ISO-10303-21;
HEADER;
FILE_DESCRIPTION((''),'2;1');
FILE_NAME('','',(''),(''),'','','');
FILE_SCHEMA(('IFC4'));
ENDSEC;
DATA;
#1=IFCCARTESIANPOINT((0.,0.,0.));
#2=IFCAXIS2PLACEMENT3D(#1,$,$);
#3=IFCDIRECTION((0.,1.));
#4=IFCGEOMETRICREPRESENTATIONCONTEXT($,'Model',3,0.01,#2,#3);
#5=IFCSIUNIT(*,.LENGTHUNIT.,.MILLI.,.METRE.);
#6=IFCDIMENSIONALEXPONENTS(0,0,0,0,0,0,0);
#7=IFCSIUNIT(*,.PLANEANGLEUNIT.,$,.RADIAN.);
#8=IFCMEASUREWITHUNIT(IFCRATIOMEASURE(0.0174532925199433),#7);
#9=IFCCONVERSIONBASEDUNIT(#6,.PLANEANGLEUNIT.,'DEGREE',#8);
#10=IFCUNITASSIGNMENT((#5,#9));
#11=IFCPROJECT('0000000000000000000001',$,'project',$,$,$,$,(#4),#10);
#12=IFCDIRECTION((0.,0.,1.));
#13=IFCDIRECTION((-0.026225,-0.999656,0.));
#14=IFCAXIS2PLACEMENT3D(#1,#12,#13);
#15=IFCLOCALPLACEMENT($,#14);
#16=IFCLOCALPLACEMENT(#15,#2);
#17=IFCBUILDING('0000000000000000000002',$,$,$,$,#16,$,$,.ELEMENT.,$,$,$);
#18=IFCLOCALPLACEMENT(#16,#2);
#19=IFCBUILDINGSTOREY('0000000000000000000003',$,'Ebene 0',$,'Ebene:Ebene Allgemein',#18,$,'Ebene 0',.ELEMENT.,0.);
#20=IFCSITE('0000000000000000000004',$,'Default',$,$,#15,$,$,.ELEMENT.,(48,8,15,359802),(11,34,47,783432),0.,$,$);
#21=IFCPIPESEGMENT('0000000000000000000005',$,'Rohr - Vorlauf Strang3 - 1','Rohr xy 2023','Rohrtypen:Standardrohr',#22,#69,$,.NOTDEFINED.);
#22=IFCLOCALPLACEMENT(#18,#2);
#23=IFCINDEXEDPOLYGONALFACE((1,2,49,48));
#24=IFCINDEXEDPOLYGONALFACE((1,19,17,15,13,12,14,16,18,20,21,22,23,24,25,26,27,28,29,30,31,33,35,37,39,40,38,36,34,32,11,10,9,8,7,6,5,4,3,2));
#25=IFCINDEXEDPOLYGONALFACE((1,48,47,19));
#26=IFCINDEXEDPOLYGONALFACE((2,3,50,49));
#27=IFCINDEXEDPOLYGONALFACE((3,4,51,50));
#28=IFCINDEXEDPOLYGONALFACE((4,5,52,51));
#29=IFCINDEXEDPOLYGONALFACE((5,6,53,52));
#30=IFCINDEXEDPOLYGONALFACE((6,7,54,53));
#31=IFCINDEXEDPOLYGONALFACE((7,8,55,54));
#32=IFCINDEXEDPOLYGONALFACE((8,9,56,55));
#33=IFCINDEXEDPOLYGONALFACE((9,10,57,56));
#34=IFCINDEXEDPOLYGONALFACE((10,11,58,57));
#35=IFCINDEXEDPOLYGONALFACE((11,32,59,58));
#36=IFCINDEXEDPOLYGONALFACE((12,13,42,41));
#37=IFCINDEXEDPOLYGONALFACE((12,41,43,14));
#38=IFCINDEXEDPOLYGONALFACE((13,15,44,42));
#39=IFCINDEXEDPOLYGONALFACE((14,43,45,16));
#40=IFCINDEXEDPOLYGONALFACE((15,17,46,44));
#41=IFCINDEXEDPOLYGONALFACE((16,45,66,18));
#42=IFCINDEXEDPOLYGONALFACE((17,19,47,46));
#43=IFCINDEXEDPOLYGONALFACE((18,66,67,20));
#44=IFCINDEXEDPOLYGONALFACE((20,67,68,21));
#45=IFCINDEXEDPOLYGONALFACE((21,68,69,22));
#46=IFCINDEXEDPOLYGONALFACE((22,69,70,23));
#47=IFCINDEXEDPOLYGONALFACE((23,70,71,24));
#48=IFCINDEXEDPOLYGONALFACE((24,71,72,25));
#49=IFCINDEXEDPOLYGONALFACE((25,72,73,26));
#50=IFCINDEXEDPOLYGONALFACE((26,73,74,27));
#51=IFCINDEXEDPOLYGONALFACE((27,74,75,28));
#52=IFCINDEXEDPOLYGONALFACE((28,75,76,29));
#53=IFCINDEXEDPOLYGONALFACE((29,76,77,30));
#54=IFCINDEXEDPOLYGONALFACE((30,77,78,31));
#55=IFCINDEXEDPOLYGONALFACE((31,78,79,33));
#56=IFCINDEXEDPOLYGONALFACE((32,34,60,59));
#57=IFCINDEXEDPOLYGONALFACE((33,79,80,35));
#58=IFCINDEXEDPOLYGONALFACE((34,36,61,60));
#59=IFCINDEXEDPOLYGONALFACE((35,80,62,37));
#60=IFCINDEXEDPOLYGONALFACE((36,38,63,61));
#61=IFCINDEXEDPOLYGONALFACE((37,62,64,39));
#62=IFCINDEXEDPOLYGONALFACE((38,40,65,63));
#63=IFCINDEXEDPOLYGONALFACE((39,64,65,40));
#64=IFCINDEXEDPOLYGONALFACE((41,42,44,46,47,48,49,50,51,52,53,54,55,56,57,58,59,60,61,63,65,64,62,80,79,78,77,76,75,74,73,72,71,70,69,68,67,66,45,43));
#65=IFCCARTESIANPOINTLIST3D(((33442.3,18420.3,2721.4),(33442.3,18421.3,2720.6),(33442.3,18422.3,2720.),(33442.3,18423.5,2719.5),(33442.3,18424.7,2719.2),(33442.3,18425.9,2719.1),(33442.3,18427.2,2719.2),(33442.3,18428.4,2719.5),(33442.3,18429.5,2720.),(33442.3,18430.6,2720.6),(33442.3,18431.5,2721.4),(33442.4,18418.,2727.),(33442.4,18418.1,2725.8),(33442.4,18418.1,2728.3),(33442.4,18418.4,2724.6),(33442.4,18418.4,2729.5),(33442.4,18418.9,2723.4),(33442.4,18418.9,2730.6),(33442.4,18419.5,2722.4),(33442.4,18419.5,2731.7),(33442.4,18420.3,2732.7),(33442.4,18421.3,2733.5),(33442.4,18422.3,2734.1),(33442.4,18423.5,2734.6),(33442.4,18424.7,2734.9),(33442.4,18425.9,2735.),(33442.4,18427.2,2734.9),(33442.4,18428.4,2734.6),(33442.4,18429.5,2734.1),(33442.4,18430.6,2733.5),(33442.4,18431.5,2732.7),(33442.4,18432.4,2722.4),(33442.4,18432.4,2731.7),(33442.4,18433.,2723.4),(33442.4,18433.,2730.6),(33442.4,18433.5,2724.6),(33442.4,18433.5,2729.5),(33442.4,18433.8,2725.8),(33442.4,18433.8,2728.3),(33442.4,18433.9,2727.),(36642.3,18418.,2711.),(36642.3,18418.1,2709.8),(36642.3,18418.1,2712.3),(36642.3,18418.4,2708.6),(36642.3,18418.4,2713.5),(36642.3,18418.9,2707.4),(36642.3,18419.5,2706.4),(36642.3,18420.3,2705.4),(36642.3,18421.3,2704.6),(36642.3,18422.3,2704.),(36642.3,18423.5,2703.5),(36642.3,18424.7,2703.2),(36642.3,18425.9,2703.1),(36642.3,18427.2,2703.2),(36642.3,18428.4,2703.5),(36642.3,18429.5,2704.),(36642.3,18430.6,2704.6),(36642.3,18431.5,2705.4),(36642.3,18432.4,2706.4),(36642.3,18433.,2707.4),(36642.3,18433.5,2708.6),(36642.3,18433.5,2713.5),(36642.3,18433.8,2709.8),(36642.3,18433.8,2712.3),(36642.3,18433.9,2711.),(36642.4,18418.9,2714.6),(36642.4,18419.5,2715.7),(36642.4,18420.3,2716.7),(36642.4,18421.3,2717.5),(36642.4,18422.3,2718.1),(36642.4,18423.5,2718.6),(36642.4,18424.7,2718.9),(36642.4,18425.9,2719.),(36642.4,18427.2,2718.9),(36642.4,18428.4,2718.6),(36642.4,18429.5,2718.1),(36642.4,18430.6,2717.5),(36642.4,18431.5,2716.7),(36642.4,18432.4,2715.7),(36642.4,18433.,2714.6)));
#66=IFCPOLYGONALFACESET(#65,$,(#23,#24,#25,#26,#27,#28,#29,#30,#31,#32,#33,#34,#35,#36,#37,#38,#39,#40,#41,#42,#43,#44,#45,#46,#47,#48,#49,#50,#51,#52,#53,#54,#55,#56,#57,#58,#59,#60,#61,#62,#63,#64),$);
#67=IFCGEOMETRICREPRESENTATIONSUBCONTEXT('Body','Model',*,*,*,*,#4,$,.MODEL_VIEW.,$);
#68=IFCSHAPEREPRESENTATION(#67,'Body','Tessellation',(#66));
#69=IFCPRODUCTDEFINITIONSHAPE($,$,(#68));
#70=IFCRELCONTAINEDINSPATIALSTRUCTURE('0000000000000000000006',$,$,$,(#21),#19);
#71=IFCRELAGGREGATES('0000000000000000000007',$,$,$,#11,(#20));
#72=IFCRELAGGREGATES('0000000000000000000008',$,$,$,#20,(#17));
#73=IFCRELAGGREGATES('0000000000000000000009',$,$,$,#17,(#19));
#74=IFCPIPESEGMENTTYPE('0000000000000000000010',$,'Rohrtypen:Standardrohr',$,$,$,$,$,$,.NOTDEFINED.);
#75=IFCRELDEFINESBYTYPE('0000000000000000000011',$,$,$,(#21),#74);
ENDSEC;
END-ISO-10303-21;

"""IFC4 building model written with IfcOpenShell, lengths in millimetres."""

from ifc_helpers import new_model, entity, si_unit, converted_unit, direction, frame, origin, place, context, subcontext, project, spatial, indexed_curve, outline, extrude, type_object, element, save


model = new_model("IFC4")

# Units and contexts
model_context = context("Model", 3, precision=0.01, world=origin(), true_north=direction((0.0, 1.0)))
body_context = subcontext(model_context, "Body", "Model", "MODEL_VIEW")
ifc_project = project(units=[si_unit("LENGTHUNIT", "METRE", prefix="MILLI"), converted_unit("PLANEANGLEUNIT", "DEGREE", entity("IfcRatioMeasure", 0.0174532925199433), si_unit("PLANEANGLEUNIT", "RADIAN"), dimensions=[0, 0, 0, 0, 0, 0, 0])], contexts=[model_context])

# Site, building, storey
site_placement = place(None, frame((0.0, 0.0, 0.0), z_axis=(0.0, 0.0, 1.0), x_axis=(-0.026225, -0.999656, 0.0)))
site = spatial("IfcSite", under=ifc_project, at=site_placement, Name="Default", CompositionType="ELEMENT", RefLatitude=(48, 8, 15, 359802), RefLongitude=(11, 34, 47, 783432), RefElevation=0.0)
building_placement = place(site_placement, origin())
building = spatial("IfcBuilding", under=site, at=building_placement, CompositionType="ELEMENT")
storey_placement = place(building_placement, origin())
storey = spatial("IfcBuildingStorey", under=building, at=storey_placement, Name="Ebene 0", ObjectType="Ebene:Ebene Allgemein", LongName="Ebene 0", CompositionType="ELEMENT", Elevation=0.0)

# Pipe segment
pipe_segment_type = type_object("IfcPipeSegmentType", Name="Rohrtypen:Standardrohr", PredefinedType="NOTDEFINED")
pipe_segment_1_placement = place(storey_placement, origin())
element("IfcPipeSegment", 1, at=pipe_segment_1_placement, inside=storey, type_object=pipe_segment_type, Name="Rohr - Vorlauf Strang3 - 1", Description="Rohr xy 2023", ObjectType="Rohrtypen:Standardrohr", PredefinedType="NOTDEFINED", context=body_context, shape_type="SweptSolid", body=[
    extrude(outline(indexed_curve([(7.9, 0.0), (7.8, 1.2), (7.6, 2.5), (7.1, 3.6), (6.4, 4.7), (5.6, 5.6), (4.7, 6.4), (3.6, 7.1), (2.5, 7.6), (1.2, 7.8), (0.0, 7.9), (-1.2, 7.8), (-2.5, 7.6), (-3.6, 7.1), (-4.7, 6.4), (-5.6, 5.6), (-6.4, 4.7), (-7.1, 3.6), (-7.6, 2.5), (-7.8, 1.2), (-7.9, 0.0), (-7.8, -1.2), (-7.6, -2.5), (-7.1, -3.6), (-6.4, -4.7), (-5.6, -5.6), (-4.7, -6.4), (-3.6, -7.1), (-2.5, -7.6), (-1.2, -7.8), (0.0, -7.9), (1.2, -7.8), (2.5, -7.6), (3.6, -7.1), (4.7, -6.4), (5.6, -5.6), (6.4, -4.7), (7.1, -3.6), (7.6, -2.5), (7.8, -1.2), (7.9, 0.0)], self_intersect=False)), frame((36642.3, 18425.9, 2711.0), z_axis=(-0.999988, 0.0, 0.005), x_axis=(0.0, 1.0, 0.0)), (0.0, 0.0, 1.0), 3200.0),
])

save(model, "model.ifc")
